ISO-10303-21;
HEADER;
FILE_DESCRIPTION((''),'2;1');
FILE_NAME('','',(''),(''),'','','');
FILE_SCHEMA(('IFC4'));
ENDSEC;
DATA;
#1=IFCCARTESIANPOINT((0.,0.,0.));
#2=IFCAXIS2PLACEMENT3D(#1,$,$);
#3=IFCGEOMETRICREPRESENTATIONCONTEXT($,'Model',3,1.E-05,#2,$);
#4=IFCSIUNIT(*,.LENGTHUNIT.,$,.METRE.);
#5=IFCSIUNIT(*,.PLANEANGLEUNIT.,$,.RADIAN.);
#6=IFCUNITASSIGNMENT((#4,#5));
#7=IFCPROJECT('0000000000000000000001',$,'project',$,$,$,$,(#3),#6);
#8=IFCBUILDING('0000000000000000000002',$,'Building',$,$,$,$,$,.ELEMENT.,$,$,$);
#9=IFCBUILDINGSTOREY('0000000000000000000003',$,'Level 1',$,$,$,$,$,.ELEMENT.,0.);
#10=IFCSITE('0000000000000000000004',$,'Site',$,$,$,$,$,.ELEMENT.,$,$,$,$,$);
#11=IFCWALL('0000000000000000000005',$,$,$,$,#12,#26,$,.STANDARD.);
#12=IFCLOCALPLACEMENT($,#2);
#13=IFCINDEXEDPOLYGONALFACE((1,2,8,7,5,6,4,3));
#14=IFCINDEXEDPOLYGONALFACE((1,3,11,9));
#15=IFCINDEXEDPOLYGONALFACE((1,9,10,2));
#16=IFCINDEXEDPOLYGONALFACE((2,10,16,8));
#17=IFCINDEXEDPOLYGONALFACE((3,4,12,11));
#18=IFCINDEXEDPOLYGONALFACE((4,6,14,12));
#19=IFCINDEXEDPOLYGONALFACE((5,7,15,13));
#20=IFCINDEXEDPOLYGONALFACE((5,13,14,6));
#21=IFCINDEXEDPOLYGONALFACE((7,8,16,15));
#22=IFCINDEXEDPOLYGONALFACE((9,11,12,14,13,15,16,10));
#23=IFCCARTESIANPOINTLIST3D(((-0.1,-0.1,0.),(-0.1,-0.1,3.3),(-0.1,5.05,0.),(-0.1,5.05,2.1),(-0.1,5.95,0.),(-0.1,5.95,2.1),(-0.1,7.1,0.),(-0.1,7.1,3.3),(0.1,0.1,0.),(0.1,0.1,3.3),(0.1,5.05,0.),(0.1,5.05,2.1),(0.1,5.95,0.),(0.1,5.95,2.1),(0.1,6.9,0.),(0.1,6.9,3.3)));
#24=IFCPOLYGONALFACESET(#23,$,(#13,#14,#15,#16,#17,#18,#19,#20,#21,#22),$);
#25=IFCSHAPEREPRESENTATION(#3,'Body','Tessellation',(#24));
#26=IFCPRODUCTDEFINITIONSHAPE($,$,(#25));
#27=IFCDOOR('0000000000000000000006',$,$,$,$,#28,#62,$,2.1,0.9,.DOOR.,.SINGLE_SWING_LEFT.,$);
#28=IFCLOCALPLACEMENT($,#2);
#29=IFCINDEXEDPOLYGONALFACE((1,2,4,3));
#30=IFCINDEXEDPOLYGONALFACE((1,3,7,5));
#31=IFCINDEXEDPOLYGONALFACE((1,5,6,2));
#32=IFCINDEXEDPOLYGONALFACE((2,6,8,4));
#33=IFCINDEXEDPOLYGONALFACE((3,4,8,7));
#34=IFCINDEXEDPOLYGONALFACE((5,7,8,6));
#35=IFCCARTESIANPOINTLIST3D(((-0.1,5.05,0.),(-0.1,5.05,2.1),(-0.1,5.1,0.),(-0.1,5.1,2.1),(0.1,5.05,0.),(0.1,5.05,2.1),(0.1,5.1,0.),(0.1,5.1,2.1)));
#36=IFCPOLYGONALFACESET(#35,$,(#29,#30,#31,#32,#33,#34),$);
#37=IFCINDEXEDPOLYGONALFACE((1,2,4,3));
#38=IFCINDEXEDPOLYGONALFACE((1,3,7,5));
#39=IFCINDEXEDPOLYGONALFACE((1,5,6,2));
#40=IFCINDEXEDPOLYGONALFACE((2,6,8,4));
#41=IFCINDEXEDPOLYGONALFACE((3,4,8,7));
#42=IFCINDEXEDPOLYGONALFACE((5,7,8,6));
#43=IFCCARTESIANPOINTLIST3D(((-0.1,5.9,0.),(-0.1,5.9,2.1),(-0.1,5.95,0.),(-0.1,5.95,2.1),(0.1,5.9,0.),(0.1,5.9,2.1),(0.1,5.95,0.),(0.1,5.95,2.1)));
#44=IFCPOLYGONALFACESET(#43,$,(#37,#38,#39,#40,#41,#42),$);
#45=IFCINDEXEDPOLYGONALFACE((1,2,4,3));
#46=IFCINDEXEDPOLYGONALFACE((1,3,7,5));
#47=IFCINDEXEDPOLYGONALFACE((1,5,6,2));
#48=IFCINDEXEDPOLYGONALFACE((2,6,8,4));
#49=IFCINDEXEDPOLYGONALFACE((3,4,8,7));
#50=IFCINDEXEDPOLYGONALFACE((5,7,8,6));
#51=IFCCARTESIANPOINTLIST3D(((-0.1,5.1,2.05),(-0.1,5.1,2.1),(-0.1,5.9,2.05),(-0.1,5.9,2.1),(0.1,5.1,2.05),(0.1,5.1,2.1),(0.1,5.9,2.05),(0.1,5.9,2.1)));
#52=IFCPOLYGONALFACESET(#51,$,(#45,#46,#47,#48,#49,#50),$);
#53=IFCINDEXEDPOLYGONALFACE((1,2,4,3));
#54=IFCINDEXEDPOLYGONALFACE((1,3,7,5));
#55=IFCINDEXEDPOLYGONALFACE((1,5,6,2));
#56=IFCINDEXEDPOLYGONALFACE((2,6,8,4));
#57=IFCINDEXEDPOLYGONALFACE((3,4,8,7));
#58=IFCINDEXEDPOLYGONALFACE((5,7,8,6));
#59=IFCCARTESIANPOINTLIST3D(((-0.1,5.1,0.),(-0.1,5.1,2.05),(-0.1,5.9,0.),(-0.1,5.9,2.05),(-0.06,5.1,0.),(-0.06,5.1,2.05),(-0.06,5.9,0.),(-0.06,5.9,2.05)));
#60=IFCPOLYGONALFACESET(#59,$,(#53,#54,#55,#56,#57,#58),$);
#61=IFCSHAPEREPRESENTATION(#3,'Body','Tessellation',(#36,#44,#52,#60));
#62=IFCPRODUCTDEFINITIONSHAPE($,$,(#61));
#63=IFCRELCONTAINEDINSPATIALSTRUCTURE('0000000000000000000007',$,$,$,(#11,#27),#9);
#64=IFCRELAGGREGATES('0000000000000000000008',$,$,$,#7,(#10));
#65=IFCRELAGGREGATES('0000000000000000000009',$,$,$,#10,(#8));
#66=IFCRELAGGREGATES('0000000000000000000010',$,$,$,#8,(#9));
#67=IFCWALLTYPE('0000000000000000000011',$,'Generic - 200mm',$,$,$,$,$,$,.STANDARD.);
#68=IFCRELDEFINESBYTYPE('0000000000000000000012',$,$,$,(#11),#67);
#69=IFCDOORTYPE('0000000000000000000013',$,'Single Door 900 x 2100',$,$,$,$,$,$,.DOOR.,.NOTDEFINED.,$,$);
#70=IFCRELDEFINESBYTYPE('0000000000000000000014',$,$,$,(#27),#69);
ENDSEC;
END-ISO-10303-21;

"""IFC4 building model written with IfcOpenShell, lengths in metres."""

from ifc_helpers import new_model, si_unit, frame, frame_2d, origin, origin_with_axes, origin_2d, place, context, project, spatial, polyline, rectangle, outline, extrude, type_object, element, fill, save


model = new_model("IFC4")

# Units and contexts
model_context = context("Model", 3, precision=1e-05, world=origin())
ifc_project = project(units=[si_unit("LENGTHUNIT", "METRE"), si_unit("PLANEANGLEUNIT", "RADIAN")], contexts=[model_context])

# Site, building, storey
site = spatial("IfcSite", under=ifc_project, Name="Site", CompositionType="ELEMENT")
building = spatial("IfcBuilding", under=site, Name="Building", CompositionType="ELEMENT")
storey = spatial("IfcBuildingStorey", under=building, Name="Level 1", CompositionType="ELEMENT", Elevation=0.0)

# Shared definitions
wall_type = type_object("IfcWallType", Name="Generic - 200mm", PredefinedType="STANDARD")

# Wall, opening, door
wall_1_placement = place(None, frame((0.0, 0.0, 0.0), z_axis=(0.0, 0.0, 1.0), x_axis=(0.0, 1.0, 0.0)))
wall_1 = element("IfcWall", 1, at=wall_1_placement, inside=storey, type_object=wall_type, PredefinedType="STANDARD", context=model_context, shape_type="SweptSolid", body=[
    extrude(outline(polyline([(0.1, -0.1), (6.9, -0.1), (7.1, 0.1), (-0.1, 0.1), (0.1, -0.1)])), origin(), (0.0, 0.0, 1.0), 3.3),
])
opening_1_placement = place(wall_1_placement, frame((5.5, 0.0, 0.0), z_axis=(0.0, 0.0, 1.0), x_axis=(1.0, 0.0, 0.0)))
opening_1 = element("IfcOpeningElement", 2, at=opening_1_placement, cuts=wall_1, PredefinedType="OPENING", context=model_context, shape_type="SweptSolid", body=[
    extrude(rectangle(XDim=0.9, YDim=0.202, at=origin_2d()), origin(), (0.0, 0.0, 1.0), 2.1),
])
door_type = type_object("IfcDoorType", Name="Single Door 900 x 2100", OperationType="NOTDEFINED", PredefinedType="DOOR")
door_placement = place(opening_1_placement, origin_with_axes())
door = element("IfcDoor", 3, at=door_placement, inside=storey, type_object=door_type, OperationType="SINGLE_SWING_LEFT", OverallHeight=2.1, OverallWidth=0.9, PredefinedType="DOOR", context=model_context, shape_type="SweptSolid", body=[
    extrude(rectangle(XDim=0.05, YDim=0.2, at=frame_2d((-0.425, 0.0))), origin(), (0.0, 0.0, 1.0), 2.1),
    extrude(rectangle(XDim=0.05, YDim=0.2, at=frame_2d((0.425, 0.0))), origin(), (0.0, 0.0, 1.0), 2.1),
    extrude(rectangle(XDim=0.8, YDim=0.2, at=origin_2d()), frame((0.0, 0.0, 2.05)), (0.0, 0.0, 1.0), 0.05),
    extrude(rectangle(XDim=0.8, YDim=0.04, at=frame_2d((0.0, 0.08))), origin(), (0.0, 0.0, 1.0), 2.05),
])
fill(opening_1, door)

save(model, "model.ifc")
